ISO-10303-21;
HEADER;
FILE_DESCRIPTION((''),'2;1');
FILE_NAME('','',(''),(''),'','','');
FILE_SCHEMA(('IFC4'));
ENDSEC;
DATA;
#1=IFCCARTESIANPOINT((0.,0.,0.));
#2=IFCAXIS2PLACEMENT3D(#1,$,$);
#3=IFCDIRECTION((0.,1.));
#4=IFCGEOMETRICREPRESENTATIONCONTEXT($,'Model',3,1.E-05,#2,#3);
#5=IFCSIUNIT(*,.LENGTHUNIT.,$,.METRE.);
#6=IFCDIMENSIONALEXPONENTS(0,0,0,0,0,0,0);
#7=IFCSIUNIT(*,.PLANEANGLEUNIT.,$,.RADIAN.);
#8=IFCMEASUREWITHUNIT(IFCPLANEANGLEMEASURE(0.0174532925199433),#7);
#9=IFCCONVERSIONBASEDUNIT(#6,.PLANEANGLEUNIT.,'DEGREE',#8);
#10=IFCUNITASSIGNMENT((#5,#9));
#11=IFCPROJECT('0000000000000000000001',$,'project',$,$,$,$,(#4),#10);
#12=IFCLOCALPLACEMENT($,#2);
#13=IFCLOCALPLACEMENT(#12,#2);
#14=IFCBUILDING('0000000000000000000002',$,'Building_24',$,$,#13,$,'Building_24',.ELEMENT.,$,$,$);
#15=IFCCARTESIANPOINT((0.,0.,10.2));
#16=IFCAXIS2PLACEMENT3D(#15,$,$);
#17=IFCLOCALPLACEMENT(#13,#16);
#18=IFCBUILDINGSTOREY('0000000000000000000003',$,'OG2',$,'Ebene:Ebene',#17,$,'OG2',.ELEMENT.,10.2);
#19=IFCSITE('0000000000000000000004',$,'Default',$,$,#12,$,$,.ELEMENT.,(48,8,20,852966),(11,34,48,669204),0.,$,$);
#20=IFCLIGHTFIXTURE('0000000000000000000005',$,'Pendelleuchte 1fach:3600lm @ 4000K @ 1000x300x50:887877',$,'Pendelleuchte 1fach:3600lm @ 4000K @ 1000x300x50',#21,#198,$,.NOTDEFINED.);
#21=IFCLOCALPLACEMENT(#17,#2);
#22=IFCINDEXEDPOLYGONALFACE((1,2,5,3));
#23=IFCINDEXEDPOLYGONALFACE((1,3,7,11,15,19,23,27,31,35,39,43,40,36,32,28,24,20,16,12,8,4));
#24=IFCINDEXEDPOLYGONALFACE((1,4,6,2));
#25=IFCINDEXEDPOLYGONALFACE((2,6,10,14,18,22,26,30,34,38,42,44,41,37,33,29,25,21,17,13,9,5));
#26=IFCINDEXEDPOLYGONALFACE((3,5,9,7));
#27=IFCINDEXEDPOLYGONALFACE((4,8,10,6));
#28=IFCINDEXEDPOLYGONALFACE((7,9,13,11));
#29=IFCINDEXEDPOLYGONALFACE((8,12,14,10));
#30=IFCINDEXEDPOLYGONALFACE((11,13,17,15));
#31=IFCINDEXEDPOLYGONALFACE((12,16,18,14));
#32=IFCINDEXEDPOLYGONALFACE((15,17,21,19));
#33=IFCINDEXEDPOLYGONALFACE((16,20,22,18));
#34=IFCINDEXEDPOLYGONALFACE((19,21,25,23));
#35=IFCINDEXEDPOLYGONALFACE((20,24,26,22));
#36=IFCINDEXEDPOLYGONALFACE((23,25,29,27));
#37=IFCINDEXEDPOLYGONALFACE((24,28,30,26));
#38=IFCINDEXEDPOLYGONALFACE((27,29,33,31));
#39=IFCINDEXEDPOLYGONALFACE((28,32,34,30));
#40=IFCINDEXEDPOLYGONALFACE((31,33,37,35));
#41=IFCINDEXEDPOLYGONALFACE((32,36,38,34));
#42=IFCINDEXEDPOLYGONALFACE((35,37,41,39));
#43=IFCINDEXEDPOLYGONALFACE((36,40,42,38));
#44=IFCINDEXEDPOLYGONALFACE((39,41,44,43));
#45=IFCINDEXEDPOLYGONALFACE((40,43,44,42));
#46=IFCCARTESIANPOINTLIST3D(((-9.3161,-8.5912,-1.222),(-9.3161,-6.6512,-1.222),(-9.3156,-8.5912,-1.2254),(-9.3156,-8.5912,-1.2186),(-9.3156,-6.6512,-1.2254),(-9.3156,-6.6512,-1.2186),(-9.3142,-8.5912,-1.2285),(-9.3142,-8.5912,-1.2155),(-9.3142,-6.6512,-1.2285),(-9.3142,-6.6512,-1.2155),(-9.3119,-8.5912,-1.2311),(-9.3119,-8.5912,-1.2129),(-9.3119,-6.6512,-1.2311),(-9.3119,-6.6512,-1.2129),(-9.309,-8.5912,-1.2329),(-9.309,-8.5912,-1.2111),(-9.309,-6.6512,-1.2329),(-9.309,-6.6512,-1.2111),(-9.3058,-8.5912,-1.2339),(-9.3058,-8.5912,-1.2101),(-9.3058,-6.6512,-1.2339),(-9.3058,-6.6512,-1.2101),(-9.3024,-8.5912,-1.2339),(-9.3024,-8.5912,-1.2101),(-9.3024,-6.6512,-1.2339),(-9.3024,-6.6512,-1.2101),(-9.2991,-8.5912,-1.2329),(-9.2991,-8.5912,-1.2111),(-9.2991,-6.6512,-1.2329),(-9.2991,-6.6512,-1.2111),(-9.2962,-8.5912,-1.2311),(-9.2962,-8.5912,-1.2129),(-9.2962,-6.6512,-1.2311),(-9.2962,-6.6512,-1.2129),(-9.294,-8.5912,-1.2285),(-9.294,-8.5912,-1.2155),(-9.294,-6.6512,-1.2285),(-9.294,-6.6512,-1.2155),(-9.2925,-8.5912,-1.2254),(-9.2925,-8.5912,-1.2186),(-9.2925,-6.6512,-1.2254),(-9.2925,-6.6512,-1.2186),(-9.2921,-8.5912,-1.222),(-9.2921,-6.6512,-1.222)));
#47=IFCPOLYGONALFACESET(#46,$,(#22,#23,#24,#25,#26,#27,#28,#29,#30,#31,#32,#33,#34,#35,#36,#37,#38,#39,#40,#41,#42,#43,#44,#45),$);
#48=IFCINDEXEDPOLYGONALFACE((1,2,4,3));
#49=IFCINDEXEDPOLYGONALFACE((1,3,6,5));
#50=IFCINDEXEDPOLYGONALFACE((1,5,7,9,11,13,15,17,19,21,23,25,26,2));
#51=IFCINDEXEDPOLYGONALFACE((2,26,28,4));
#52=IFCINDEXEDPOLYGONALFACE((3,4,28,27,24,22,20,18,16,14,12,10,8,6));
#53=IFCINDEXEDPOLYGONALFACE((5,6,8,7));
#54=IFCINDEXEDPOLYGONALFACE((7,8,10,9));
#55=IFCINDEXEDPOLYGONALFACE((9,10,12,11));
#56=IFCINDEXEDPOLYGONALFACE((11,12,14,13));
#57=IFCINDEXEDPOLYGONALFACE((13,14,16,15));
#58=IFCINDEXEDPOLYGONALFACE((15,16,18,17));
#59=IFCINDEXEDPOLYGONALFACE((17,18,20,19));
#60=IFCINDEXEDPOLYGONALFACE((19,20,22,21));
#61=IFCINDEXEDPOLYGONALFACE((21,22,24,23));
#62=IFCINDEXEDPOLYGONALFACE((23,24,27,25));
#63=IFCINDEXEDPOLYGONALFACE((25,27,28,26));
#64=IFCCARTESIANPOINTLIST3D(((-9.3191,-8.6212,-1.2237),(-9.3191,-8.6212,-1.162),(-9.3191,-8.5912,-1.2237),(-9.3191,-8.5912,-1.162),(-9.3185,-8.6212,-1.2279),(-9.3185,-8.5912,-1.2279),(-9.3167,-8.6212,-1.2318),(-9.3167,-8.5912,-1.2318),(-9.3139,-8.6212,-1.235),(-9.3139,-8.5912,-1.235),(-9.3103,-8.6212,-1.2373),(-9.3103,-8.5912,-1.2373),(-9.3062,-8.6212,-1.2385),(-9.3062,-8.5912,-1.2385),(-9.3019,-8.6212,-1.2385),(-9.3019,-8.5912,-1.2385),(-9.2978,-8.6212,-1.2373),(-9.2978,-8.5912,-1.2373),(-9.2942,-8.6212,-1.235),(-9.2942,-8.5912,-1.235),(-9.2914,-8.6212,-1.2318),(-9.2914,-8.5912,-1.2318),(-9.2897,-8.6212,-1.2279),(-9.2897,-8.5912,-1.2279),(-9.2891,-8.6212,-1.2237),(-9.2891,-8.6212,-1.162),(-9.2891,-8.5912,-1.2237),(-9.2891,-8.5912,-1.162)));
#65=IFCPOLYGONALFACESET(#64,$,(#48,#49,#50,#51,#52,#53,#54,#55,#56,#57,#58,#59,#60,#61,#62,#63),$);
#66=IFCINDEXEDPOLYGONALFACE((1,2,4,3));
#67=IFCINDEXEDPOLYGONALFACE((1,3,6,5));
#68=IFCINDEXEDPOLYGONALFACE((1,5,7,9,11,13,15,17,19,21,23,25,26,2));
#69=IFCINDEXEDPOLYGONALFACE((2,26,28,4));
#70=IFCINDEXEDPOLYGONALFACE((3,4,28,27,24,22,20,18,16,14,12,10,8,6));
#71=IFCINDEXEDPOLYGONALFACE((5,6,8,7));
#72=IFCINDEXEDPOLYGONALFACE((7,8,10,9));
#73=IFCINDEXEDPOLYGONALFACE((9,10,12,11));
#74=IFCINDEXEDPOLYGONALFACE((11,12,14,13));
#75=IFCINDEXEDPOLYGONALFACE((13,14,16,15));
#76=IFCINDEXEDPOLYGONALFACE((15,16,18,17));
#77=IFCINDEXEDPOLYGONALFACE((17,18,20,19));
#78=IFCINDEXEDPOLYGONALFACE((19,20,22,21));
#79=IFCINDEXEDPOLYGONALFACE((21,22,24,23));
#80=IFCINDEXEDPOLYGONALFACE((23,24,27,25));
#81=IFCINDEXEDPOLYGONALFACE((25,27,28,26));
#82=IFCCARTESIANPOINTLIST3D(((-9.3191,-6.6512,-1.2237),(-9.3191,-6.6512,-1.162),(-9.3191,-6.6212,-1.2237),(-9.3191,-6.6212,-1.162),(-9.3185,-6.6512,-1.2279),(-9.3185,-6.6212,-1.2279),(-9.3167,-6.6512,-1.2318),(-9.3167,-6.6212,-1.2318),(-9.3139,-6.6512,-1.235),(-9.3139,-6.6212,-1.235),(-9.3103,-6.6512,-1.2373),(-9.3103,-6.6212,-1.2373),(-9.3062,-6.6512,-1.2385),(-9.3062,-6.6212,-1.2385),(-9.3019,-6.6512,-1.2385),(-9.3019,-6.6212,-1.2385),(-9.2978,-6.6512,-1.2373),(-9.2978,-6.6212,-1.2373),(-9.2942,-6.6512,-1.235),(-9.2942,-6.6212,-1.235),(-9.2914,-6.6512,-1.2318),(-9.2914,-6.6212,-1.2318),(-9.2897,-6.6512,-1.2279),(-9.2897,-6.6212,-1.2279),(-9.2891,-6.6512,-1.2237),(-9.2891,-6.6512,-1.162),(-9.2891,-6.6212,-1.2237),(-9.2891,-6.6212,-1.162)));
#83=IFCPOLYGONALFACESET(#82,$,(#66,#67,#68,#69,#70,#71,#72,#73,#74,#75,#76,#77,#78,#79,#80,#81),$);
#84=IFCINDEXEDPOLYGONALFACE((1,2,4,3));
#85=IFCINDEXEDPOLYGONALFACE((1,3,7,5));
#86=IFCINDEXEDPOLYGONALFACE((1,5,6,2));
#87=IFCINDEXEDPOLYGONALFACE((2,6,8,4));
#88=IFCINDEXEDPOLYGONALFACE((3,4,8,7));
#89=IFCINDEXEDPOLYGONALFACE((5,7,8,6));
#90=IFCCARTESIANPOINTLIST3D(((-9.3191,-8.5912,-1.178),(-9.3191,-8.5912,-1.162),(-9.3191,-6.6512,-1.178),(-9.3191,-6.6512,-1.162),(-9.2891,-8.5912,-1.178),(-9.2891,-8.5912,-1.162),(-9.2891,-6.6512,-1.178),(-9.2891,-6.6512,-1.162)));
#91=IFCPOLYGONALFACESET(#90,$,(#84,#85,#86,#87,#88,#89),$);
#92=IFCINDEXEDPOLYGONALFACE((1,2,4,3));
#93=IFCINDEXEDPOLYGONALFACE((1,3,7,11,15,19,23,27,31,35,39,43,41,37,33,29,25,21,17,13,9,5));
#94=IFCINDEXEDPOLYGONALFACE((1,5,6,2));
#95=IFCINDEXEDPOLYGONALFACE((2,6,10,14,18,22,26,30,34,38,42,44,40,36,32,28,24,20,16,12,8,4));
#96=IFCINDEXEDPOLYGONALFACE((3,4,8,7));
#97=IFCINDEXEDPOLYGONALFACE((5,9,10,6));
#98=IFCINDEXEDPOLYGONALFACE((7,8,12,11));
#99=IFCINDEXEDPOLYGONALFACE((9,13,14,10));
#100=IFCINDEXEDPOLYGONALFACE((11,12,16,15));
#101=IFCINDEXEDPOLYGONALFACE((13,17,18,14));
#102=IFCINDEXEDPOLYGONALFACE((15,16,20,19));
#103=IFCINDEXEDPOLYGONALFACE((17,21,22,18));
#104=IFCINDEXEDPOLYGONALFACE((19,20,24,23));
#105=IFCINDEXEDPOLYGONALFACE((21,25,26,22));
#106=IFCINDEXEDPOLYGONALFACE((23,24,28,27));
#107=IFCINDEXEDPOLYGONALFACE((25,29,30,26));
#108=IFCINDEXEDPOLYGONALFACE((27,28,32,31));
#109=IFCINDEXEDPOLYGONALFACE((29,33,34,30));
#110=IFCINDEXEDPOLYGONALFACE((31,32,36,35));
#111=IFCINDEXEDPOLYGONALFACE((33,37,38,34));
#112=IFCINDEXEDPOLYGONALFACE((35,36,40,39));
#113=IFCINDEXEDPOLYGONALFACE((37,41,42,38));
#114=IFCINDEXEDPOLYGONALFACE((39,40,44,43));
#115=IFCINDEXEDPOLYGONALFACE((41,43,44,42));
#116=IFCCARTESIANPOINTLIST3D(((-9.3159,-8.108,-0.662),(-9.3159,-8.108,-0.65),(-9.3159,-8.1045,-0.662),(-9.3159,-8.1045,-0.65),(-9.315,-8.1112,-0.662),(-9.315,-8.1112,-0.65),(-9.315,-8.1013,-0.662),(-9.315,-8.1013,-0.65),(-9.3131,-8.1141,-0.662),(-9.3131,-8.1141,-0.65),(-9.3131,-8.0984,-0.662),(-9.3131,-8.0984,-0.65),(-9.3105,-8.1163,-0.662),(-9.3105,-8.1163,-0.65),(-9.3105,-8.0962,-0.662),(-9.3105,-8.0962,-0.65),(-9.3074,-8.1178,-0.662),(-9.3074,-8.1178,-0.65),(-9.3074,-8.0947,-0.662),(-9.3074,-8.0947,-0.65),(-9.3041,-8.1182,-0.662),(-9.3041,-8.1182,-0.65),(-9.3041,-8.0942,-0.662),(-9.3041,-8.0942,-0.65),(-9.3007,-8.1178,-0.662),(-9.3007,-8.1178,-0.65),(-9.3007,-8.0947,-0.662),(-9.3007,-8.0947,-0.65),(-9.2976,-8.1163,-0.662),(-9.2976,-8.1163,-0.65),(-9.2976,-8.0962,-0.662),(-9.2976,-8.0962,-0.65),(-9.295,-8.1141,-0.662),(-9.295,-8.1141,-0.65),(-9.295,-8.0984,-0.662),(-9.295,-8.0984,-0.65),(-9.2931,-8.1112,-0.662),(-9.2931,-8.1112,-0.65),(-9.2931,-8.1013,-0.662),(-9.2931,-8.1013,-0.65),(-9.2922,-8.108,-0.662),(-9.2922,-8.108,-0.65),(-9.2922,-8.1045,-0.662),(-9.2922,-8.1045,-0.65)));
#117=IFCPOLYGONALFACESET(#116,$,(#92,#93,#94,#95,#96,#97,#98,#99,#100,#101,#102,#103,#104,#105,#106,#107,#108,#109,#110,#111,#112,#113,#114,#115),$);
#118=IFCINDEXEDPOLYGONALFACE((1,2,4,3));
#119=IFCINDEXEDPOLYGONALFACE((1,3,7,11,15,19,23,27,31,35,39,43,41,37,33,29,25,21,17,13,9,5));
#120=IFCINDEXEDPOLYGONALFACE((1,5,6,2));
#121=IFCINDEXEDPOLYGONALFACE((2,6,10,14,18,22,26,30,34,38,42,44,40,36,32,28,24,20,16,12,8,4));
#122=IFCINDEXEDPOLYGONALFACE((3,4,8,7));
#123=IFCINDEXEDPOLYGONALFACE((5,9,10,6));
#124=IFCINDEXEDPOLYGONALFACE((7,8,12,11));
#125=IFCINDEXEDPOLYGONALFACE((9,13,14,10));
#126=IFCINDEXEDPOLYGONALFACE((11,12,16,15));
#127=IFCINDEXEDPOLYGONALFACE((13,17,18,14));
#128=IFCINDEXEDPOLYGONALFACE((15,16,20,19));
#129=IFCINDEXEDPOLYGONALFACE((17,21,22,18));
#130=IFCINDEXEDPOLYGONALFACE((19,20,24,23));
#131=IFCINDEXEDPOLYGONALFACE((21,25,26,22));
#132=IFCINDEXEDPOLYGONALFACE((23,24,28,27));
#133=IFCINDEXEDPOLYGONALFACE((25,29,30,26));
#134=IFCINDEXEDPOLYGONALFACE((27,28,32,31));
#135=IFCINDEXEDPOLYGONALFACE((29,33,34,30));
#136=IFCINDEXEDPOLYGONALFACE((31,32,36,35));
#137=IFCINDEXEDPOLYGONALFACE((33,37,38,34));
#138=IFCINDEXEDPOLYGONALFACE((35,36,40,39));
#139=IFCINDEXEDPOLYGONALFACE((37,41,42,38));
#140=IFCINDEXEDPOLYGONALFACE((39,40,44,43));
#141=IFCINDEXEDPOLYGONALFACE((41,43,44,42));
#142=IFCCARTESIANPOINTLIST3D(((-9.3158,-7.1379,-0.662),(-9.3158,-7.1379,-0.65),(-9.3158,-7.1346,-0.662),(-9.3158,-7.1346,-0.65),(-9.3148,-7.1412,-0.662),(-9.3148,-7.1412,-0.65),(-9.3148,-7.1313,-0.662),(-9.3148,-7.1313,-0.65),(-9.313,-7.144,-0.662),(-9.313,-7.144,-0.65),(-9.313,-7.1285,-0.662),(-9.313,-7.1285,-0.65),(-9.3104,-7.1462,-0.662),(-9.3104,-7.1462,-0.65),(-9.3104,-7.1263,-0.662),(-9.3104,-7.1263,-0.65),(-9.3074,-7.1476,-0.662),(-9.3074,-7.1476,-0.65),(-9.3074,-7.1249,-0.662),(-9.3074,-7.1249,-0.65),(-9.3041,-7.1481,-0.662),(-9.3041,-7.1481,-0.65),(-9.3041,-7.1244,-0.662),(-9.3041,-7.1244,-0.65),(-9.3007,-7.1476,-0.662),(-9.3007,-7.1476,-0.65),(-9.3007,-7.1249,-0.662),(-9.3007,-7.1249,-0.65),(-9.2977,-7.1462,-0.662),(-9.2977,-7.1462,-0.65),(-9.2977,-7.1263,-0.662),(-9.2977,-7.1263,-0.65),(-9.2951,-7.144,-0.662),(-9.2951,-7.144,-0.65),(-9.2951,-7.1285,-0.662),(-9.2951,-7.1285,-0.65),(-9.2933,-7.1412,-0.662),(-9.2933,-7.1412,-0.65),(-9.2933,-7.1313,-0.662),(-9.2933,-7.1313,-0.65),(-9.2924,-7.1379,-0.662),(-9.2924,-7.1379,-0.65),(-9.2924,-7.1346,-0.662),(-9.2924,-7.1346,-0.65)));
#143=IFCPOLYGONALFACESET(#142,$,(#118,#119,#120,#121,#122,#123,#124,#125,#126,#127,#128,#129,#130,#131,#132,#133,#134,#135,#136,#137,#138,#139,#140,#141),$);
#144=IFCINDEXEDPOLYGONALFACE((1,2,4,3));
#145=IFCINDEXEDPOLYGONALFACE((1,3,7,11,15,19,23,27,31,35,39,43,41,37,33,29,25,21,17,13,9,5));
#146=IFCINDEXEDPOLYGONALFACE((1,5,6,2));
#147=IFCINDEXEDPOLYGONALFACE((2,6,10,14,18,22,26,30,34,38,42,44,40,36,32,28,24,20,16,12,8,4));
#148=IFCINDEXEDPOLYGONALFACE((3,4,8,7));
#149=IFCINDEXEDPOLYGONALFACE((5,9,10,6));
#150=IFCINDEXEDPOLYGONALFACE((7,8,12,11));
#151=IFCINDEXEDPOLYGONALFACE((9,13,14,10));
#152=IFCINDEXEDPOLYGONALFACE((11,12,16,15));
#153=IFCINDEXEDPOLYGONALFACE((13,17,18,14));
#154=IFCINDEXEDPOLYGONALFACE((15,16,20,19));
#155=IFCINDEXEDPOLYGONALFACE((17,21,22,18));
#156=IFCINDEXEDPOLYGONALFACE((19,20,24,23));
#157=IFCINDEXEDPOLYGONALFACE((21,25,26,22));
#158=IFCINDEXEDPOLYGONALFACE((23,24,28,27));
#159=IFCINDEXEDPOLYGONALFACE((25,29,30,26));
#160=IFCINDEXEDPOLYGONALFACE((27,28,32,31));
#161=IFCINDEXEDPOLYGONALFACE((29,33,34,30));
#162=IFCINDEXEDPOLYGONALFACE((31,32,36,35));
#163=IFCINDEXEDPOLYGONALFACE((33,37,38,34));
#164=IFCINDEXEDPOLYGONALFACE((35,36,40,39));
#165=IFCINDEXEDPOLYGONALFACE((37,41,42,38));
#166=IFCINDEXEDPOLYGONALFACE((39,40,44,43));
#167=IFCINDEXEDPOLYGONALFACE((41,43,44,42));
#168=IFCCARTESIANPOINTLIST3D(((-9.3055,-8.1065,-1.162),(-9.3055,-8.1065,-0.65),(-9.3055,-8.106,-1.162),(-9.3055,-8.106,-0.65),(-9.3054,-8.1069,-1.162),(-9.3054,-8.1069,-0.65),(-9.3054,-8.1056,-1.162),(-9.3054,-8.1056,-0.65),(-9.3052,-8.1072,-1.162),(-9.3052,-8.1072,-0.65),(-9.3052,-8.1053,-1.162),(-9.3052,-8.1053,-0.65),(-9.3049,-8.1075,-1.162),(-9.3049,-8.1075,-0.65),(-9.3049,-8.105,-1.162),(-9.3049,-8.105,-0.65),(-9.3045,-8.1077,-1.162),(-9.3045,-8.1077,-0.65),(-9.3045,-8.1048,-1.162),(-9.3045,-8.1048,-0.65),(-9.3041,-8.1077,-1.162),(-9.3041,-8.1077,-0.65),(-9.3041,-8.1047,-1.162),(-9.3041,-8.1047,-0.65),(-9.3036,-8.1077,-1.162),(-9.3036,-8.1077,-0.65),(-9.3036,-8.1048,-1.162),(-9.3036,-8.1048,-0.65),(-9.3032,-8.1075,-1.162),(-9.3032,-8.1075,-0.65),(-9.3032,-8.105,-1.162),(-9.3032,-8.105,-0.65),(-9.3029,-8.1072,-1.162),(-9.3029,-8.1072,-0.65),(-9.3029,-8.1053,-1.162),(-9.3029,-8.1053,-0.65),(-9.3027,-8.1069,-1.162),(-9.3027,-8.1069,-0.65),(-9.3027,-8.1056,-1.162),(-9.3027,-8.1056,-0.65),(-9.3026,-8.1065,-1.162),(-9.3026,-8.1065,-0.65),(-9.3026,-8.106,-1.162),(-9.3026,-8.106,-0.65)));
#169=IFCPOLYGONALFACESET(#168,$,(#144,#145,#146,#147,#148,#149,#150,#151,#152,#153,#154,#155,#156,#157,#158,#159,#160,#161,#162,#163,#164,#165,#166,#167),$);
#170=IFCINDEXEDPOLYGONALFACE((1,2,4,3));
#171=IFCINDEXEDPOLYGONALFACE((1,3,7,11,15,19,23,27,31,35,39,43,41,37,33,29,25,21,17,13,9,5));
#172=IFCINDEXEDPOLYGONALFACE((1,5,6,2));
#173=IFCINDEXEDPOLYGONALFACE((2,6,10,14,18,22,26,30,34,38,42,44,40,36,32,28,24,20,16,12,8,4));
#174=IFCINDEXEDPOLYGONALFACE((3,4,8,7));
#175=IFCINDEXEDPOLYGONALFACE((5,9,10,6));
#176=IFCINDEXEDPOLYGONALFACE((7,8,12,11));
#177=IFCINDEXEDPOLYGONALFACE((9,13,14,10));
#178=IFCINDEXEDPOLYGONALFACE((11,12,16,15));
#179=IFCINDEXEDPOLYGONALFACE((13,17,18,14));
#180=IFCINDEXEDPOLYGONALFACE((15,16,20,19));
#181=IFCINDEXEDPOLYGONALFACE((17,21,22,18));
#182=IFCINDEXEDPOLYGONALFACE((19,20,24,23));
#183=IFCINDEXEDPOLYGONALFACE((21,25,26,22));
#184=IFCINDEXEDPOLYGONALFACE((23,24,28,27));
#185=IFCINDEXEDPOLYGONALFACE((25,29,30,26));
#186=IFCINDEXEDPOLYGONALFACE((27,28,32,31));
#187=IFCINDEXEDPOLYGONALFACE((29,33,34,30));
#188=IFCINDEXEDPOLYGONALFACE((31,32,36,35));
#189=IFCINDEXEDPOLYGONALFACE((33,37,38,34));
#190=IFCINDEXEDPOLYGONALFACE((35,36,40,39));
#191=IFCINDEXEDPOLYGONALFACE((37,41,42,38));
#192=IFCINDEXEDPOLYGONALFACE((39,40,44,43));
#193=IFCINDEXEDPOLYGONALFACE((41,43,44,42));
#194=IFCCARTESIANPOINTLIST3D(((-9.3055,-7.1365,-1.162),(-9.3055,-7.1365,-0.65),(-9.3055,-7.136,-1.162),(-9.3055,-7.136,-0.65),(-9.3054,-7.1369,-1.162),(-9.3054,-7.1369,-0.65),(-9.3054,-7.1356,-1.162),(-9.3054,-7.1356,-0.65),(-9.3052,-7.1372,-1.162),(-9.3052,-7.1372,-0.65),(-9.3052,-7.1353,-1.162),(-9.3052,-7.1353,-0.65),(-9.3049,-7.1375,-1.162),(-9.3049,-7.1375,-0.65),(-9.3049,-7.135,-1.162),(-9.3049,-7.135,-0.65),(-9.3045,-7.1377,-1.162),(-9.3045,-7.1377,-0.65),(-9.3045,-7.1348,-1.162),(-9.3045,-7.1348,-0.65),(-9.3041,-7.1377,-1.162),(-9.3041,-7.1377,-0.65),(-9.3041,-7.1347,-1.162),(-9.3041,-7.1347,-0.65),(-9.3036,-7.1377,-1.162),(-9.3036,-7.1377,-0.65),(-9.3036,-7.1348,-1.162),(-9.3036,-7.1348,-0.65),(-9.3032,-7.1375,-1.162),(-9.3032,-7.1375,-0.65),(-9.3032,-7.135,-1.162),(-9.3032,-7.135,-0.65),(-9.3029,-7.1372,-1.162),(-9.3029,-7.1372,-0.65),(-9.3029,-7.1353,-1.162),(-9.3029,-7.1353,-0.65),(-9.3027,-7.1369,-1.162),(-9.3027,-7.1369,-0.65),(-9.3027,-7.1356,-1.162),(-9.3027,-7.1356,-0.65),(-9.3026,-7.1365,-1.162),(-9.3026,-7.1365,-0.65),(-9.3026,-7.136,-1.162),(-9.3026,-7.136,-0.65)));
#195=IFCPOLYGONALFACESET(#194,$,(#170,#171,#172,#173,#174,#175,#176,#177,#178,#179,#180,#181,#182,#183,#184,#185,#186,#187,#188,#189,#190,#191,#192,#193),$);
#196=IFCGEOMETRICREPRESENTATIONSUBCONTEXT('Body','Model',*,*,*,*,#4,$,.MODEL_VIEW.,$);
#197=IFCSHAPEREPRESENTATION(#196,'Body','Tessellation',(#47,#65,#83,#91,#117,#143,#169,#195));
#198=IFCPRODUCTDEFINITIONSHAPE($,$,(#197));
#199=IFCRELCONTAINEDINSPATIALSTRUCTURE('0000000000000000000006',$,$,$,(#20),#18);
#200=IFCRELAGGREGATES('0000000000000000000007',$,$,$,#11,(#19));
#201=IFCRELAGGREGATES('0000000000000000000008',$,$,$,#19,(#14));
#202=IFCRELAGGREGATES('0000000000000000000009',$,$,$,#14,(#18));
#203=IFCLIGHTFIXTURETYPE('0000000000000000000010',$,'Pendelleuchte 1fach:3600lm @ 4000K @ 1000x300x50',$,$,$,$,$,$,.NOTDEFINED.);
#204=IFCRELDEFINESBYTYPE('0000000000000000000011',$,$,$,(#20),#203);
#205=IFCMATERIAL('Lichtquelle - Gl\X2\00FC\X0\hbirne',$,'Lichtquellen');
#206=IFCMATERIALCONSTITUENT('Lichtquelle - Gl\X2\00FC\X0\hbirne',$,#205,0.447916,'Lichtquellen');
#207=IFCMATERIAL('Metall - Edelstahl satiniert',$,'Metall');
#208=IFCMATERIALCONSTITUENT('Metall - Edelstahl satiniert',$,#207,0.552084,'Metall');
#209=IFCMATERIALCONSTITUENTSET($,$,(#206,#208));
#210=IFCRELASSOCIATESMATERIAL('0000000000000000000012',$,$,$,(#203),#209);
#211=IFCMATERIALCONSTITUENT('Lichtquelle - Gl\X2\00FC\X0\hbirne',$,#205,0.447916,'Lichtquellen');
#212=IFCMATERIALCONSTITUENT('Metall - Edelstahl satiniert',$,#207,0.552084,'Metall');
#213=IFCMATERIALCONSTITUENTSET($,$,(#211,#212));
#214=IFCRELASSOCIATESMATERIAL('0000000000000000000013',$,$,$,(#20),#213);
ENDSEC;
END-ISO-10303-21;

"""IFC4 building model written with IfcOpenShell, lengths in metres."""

from ifc_helpers import new_model, entity, si_unit, converted_unit, direction, frame, origin, place, context, subcontext, project, spatial, line, arc, indexed_curve, outline, extrude, source, transform, mapped, material, constituent, constituent_set, type_object, type_shapes, element, save


model = new_model("IFC4")

# Units and contexts
model_context = context("Model", 3, precision=1e-05, world=origin(), true_north=direction((0.0, 1.0)))
body_context = subcontext(model_context, "Body", "Model", "MODEL_VIEW")
ifc_project = project(units=[si_unit("LENGTHUNIT", "METRE"), converted_unit("PLANEANGLEUNIT", "DEGREE", entity("IfcPlaneAngleMeasure", 0.0174532925199433), si_unit("PLANEANGLEUNIT", "RADIAN"), dimensions=[0, 0, 0, 0, 0, 0, 0])], contexts=[model_context])

# Site, building, storey
site_placement = place(None, origin())
site = spatial("IfcSite", under=ifc_project, at=site_placement, Name="Default", CompositionType="ELEMENT", RefLatitude=(48, 8, 20, 852966), RefLongitude=(11, 34, 48, 669204), RefElevation=0.0)
building_placement = place(site_placement, origin())
building = spatial("IfcBuilding", under=site, at=building_placement, Name="Building_24", LongName="Building_24", CompositionType="ELEMENT")
storey_placement = place(building_placement, frame((0.0, 0.0, 10.2)))
storey = spatial("IfcBuildingStorey", under=building, at=storey_placement, Name="OG2", ObjectType="Ebene:Ebene", LongName="OG2", CompositionType="ELEMENT", Elevation=10.2)

# Light fixture
ifc_material_1 = material(Name="Lichtquelle - Glühbirne", Category="Lichtquellen")
ifc_material_2 = material(Name="Metall - Edelstahl satiniert", Category="Metall")
ifc_constituent_1 = constituent(ifc_material_1, Name="Lichtquelle - Glühbirne", Category="Lichtquellen", fraction=0.447916)
ifc_constituent_2 = constituent(ifc_material_2, Name="Metall - Edelstahl satiniert", Category="Metall", fraction=0.552084)
ifc_constituent_set_1 = constituent_set(constituents=[ifc_constituent_1, ifc_constituent_2])
light_fixture_type_1 = type_object("IfcLightFixtureType", Name="Pendelleuchte 1fach:3600lm @ 4000K @ 1000x300x50", PredefinedType="NOTDEFINED", material=ifc_constituent_set_1)
shared_shape_1 = source(origin(), body_context, "Body", "SweptSolid", [
    extrude(outline(indexed_curve([(-0.012, 0.0), (0.0, -0.012), (0.012, 0.0), (0.0, 0.012)], segments=[arc(1, 2, 3), arc(3, 4, 1)], self_intersect=False)), frame((-0.97, 0.0, -0.572), z_axis=(1.0, 0.0, 0.0), x_axis=(0.0, 1.0, 0.0)), (0.0, 0.0, 1.0), 1.94),
    extrude(outline(indexed_curve([(-0.0308, -0.015), (0.0308, -0.015), (0.0308, 0.015), (-0.0308, 0.015), (-0.0458, 0.0)], segments=[line(1, 2, 3, 4), arc(4, 5, 1)], self_intersect=False)), frame((0.97, 0.0, -0.5428), z_axis=(1.0, 0.0, 0.0), x_axis=(0.0, 0.0, 1.0)), (0.0, 0.0, 1.0), 0.03),
    extrude(outline(indexed_curve([(-0.0308, -0.015), (0.0308, -0.015), (0.0308, 0.015), (-0.0308, 0.015), (-0.0458, 0.0)], segments=[line(1, 2, 3, 4), arc(4, 5, 1)], self_intersect=False)), frame((-1.0, 0.0, -0.5428), z_axis=(1.0, 0.0, 0.0), x_axis=(0.0, 0.0, 1.0)), (0.0, 0.0, 1.0), 0.03),
    extrude(outline(indexed_curve([(-0.97, -0.015), (0.97, -0.015), (0.97, 0.015), (-0.97, 0.015), (-0.97, -0.015)], self_intersect=False)), frame((0.0, 0.0, -0.528), z_axis=(0.0, 0.0, 1.0), x_axis=(-1.0, 0.0, 0.0)), (0.0, 0.0, 1.0), 0.016),
    extrude(outline(indexed_curve([(-0.012, 0.0), (0.0, -0.012), (0.012, 0.0), (0.0, 0.012)], segments=[arc(1, 2, 3), arc(3, 4, 1)], self_intersect=False)), frame((0.485, 0.0, -0.012)), (0.0, 0.0, 1.0), 0.012),
    extrude(outline(indexed_curve([(-0.0118, 0.0), (0.0, -0.0118), (0.0118, 0.0), (0.0, 0.0118)], segments=[arc(1, 2, 3), arc(3, 4, 1)], self_intersect=False)), frame((-0.485, 0.0, -0.012)), (0.0, 0.0, 1.0), 0.012),
    extrude(outline(indexed_curve([(-0.0015, 0.0), (0.0, -0.0015), (0.0015, 0.0), (0.0, 0.0015)], segments=[arc(1, 2, 3), arc(3, 4, 1)], self_intersect=False)), frame((0.485, 0.0, -0.512)), (0.0, 0.0, 1.0), 0.512),
    extrude(outline(indexed_curve([(-0.0015, 0.0), (0.0, -0.0015), (0.0015, 0.0), (0.0, 0.0015)], segments=[arc(1, 2, 3), arc(3, 4, 1)], self_intersect=False)), frame((-0.485, 0.0, -0.512)), (0.0, 0.0, 1.0), 0.512),
])
type_shapes(light_fixture_type_1, [shared_shape_1])
ifc_constituent_3 = constituent(ifc_material_1, Name="Lichtquelle - Glühbirne", Category="Lichtquellen", fraction=0.447916)
ifc_constituent_4 = constituent(ifc_material_2, Name="Metall - Edelstahl satiniert", Category="Metall", fraction=0.552084)
ifc_constituent_set_2 = constituent_set(constituents=[ifc_constituent_3, ifc_constituent_4])
light_fixture_1_placement = place(storey_placement, frame((-9.3041, -7.6212, -0.65), z_axis=(0.0, 0.0, 1.0), x_axis=(0.0, -1.0, 0.0)))
element("IfcLightFixture", 1, at=light_fixture_1_placement, inside=storey, type_object=light_fixture_type_1, material=ifc_constituent_set_2, Name="Pendelleuchte 1fach:3600lm @ 4000K @ 1000x300x50:887877", ObjectType="Pendelleuchte 1fach:3600lm @ 4000K @ 1000x300x50", PredefinedType="NOTDEFINED", context=body_context, shape_type="MappedRepresentation", body=[
    mapped(shared_shape_1, transform((0.0, 0.0, 0.0), scale=1.0)),
])

save(model, "model.ifc")
